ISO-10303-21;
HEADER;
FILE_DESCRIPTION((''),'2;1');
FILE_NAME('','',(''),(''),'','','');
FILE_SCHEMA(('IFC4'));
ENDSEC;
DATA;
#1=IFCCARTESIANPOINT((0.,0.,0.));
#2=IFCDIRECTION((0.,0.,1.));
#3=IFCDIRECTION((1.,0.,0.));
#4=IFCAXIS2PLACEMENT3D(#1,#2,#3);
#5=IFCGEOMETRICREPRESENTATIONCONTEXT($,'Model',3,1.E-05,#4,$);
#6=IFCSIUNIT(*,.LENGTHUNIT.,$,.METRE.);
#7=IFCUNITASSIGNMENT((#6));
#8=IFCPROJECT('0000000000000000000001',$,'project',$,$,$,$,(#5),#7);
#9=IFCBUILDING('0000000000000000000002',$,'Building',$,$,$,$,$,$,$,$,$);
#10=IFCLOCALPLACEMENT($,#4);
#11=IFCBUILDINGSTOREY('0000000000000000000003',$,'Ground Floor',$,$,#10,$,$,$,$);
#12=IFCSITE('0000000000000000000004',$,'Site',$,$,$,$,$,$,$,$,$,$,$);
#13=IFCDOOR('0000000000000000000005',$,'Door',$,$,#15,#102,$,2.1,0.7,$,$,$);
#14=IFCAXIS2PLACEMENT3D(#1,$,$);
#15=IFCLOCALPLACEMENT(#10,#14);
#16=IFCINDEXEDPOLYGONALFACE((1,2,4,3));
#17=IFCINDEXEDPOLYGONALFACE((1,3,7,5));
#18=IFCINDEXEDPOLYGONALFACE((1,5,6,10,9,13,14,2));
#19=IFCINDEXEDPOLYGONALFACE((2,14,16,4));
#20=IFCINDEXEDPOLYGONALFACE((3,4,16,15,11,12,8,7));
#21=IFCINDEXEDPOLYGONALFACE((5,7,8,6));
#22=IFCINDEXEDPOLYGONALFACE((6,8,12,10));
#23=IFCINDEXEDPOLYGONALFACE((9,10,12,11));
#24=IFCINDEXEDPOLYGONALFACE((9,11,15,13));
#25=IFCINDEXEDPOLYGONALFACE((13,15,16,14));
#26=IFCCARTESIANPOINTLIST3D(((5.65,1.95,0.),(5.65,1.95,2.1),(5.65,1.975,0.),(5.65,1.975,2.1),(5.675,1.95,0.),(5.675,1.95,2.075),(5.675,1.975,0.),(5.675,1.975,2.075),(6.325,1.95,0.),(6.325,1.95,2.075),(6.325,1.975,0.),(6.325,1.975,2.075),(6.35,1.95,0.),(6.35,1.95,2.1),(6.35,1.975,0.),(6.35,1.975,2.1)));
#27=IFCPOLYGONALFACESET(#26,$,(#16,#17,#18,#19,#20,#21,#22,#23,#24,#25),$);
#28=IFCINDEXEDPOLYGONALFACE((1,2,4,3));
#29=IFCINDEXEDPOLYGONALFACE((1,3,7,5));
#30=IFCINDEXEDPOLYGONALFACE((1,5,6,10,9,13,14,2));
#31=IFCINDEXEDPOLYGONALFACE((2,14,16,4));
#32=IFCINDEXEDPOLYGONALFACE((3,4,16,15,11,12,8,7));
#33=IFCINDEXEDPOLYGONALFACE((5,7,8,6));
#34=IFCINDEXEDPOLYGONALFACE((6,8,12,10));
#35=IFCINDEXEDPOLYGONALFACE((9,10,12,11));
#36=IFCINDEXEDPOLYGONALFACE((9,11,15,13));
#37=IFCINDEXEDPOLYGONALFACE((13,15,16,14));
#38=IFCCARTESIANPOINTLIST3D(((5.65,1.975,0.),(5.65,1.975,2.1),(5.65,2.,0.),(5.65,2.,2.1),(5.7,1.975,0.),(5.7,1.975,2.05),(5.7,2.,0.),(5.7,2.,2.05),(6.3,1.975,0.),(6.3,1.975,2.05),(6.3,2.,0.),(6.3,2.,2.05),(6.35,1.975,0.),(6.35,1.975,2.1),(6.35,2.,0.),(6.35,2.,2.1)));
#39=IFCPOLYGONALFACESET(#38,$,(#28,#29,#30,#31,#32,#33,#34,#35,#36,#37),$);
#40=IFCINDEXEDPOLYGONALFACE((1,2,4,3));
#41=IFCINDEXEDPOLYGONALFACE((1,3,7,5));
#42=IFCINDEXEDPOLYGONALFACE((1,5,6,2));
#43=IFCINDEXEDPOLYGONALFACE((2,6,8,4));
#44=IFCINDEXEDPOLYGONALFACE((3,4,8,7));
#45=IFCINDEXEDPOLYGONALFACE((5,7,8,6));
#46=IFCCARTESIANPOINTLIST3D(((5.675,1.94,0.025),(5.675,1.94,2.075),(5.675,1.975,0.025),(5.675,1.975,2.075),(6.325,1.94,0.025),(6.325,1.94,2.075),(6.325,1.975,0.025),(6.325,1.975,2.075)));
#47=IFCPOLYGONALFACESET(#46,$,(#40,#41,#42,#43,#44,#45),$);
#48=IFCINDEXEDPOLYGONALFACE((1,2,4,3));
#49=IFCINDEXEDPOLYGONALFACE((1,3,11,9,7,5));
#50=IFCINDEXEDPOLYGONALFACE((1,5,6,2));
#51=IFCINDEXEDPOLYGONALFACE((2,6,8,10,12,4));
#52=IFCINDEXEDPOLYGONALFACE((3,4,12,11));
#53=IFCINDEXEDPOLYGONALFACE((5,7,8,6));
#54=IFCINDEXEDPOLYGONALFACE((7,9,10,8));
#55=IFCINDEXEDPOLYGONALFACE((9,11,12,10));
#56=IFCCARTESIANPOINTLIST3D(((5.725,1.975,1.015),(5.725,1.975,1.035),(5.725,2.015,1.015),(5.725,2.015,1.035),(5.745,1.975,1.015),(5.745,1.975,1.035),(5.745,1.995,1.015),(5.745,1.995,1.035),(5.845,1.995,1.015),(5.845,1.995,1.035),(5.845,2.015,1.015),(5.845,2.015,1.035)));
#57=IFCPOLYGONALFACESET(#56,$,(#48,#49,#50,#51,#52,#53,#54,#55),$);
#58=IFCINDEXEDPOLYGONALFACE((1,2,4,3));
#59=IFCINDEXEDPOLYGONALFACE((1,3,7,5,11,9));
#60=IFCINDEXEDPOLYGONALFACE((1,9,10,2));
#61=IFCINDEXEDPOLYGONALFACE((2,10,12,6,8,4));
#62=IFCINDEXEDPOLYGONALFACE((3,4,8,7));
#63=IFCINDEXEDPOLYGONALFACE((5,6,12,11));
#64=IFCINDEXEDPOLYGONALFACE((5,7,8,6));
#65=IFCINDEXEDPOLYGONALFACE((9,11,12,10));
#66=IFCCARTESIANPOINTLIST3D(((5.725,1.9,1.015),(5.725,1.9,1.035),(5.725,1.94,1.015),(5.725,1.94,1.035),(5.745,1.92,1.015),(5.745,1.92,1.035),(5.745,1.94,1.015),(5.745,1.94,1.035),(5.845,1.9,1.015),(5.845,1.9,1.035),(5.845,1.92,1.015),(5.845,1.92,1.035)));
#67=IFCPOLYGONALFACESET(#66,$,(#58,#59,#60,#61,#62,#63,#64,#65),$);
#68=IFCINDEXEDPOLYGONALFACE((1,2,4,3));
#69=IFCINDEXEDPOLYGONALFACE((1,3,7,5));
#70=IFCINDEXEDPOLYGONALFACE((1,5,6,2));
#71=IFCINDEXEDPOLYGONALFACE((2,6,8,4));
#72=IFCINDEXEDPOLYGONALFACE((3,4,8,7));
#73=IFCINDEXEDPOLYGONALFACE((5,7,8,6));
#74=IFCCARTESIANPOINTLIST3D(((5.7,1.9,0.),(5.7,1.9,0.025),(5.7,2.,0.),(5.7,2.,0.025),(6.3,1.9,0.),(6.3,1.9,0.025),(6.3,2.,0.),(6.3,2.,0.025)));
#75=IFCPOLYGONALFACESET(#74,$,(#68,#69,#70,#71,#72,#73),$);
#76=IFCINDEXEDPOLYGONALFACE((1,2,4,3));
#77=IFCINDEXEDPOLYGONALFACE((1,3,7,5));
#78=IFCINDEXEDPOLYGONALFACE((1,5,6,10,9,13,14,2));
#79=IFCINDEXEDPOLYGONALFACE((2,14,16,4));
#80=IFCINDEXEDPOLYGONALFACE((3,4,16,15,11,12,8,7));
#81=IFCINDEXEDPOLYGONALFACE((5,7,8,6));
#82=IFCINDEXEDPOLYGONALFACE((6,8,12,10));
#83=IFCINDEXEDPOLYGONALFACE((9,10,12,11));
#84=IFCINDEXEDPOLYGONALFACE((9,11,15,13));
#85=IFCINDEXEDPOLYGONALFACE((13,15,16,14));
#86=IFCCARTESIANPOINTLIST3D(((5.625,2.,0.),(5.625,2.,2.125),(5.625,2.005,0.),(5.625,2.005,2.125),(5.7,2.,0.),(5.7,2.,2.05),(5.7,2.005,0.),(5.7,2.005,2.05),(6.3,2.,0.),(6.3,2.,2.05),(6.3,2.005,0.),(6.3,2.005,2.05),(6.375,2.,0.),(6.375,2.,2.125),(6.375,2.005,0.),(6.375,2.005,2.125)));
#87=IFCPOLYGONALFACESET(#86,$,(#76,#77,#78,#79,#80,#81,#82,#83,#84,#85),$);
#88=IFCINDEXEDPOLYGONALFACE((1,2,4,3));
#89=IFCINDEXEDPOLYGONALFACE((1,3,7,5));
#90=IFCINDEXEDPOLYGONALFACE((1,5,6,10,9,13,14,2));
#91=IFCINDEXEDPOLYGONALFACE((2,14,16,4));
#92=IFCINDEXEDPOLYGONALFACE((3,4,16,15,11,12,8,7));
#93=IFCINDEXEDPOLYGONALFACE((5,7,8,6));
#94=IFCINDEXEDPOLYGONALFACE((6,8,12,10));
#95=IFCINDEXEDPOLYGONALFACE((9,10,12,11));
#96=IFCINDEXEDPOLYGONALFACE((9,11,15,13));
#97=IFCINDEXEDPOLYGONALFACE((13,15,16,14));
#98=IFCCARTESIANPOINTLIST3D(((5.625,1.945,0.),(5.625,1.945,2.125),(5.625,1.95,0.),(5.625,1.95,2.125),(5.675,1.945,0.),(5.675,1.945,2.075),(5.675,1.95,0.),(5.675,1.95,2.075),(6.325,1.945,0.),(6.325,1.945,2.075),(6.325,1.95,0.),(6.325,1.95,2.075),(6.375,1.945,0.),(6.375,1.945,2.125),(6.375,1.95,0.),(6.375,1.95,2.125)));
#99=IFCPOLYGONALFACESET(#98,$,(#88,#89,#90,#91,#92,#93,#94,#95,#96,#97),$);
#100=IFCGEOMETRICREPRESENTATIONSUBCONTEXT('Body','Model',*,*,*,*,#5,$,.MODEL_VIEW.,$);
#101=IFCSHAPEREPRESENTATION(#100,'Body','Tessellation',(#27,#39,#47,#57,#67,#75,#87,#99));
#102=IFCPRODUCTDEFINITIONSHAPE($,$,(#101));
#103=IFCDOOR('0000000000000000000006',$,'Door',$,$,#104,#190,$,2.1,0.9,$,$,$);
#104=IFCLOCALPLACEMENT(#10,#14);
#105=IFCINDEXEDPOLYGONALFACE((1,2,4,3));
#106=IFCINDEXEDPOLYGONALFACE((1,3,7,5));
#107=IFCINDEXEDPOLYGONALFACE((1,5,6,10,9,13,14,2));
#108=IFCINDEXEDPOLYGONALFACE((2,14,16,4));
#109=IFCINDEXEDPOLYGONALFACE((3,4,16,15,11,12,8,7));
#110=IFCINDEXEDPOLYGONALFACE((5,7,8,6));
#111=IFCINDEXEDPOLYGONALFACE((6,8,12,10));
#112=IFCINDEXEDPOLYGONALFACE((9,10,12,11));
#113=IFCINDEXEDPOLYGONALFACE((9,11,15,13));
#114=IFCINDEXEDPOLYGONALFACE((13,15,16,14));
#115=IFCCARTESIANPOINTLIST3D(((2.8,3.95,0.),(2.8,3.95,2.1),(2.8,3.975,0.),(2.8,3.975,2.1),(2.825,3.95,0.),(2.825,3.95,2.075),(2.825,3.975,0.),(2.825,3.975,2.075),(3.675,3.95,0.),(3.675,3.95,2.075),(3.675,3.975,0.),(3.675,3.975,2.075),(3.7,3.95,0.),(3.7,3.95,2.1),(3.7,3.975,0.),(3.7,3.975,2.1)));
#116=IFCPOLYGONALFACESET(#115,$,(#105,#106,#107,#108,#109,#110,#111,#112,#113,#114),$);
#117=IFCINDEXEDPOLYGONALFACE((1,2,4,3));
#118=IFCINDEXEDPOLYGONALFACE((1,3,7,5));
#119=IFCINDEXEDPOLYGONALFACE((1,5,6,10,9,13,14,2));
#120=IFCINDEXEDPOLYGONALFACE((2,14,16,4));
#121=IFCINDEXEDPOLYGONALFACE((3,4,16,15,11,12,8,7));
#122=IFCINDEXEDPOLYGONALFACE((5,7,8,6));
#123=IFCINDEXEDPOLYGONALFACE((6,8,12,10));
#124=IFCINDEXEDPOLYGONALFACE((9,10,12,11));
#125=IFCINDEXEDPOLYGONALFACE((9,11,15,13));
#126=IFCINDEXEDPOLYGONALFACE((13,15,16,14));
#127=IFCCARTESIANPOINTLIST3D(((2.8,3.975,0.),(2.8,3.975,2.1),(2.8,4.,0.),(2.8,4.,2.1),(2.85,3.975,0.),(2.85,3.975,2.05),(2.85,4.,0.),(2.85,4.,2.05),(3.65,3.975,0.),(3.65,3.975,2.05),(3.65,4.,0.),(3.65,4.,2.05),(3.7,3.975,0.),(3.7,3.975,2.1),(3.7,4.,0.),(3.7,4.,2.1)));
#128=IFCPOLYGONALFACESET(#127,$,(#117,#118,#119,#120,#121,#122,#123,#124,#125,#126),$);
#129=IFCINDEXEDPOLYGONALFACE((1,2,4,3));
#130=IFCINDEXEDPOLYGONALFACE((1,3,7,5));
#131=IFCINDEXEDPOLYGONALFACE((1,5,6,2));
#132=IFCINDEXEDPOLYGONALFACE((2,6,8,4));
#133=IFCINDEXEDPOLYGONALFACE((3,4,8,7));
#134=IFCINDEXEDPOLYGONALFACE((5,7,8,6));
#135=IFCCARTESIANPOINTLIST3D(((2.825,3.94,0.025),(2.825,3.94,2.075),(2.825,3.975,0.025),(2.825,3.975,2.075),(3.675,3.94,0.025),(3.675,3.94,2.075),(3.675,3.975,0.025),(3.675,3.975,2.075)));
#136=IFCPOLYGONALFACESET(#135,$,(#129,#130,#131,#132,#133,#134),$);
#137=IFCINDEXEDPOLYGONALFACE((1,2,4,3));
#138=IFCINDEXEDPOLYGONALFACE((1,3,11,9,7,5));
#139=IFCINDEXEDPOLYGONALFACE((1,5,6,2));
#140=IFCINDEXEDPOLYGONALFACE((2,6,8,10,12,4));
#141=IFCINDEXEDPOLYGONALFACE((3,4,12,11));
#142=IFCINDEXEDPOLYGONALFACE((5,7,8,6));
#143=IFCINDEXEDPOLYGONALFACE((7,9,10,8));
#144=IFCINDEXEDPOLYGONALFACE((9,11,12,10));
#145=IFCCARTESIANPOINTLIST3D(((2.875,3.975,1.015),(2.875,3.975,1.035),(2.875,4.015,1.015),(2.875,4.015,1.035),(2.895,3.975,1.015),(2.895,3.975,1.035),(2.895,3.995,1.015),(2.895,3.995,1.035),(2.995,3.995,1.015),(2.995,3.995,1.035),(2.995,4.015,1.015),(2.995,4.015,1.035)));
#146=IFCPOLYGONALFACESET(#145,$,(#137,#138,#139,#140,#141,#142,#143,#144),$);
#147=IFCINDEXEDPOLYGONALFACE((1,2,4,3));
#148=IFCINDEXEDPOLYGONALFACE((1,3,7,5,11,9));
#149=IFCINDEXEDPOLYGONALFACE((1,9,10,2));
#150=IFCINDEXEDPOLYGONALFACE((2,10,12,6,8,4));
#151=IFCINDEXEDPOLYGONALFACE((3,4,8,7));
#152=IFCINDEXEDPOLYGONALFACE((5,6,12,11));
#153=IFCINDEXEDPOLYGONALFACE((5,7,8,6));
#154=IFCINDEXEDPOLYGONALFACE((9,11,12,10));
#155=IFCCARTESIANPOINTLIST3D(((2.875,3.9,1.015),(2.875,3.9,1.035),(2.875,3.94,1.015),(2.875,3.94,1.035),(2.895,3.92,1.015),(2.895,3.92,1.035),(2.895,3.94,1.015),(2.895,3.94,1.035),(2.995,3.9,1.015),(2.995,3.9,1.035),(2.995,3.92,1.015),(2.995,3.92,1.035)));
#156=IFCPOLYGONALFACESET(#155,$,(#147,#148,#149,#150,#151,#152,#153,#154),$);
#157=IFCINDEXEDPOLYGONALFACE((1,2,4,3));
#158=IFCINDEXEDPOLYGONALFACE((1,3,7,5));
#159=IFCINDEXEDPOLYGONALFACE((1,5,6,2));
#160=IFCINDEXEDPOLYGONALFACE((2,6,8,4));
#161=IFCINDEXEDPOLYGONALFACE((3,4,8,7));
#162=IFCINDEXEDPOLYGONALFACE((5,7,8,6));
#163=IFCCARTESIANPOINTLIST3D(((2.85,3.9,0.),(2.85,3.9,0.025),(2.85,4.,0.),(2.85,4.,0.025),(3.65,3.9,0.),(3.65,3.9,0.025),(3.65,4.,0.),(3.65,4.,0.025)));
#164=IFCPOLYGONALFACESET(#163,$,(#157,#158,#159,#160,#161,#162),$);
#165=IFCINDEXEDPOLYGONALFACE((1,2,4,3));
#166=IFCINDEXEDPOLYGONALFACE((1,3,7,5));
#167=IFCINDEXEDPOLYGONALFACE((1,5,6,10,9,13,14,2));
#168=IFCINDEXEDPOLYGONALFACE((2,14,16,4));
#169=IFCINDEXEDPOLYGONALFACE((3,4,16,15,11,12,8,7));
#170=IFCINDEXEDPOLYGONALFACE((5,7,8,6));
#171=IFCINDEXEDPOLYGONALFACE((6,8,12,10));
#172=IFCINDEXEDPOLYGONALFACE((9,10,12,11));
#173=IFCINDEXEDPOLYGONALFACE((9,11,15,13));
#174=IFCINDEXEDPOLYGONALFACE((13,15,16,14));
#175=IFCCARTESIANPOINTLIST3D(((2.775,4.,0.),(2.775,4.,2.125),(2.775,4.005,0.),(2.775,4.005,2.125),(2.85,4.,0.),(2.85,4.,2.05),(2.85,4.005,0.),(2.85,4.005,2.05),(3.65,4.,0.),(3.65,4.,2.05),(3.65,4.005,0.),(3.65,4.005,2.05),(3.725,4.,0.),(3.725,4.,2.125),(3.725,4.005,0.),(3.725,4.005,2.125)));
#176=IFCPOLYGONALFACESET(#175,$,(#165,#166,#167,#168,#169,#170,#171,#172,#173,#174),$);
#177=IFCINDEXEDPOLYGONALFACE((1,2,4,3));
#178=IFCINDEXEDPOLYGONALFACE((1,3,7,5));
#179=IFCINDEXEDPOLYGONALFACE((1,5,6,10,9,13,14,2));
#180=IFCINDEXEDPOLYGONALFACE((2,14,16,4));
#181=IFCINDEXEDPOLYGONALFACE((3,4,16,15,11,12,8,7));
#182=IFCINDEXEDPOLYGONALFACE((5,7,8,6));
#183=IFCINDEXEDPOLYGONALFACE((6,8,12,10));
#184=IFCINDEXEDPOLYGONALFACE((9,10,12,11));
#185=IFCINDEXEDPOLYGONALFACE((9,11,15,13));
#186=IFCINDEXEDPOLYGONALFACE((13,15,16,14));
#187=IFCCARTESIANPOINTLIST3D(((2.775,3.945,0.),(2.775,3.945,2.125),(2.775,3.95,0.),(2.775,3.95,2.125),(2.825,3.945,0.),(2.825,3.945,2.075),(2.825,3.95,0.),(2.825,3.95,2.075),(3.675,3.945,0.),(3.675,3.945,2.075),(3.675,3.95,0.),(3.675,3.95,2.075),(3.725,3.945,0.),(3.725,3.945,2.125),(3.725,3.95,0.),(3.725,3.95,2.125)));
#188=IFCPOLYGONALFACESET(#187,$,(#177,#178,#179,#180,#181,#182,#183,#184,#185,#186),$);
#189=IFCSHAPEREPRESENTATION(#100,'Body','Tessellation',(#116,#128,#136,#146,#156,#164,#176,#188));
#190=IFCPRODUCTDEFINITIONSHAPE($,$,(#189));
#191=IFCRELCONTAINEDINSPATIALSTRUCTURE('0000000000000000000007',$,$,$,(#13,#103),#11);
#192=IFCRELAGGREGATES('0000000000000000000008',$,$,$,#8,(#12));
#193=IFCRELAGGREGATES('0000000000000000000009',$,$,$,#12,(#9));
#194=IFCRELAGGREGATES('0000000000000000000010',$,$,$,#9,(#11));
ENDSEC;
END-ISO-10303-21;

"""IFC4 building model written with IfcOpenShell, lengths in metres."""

from ifc_helpers import new_model, si_unit, frame, origin_with_axes, place, context, subcontext, project, spatial, line, indexed_curve, outline, extrude, element, save


model = new_model("IFC4")

# Units and contexts
model_context = context("Model", 3, precision=1e-05, world=origin_with_axes())
body_context = subcontext(model_context, "Body", "Model", "MODEL_VIEW")
ifc_project = project(units=[si_unit("LENGTHUNIT", "METRE")], contexts=[model_context])

# Site, building, storey
site = spatial("IfcSite", under=ifc_project, Name="Site")
building = spatial("IfcBuilding", under=site, Name="Building")
storey_placement = place(None, origin_with_axes())
storey = spatial("IfcBuildingStorey", under=building, at=storey_placement, Name="Ground Floor")

# Doors
door_1_placement = place(storey_placement, frame((6.35, 2.0, 0.0), z_axis=(0.0, 0.0, 1.0), x_axis=(-1.0, 0.0, 0.0)))
element("IfcDoor", 1, at=door_1_placement, inside=storey, Name="Door", OverallHeight=2.1, OverallWidth=0.7, context=body_context, shape_type="SweptSolid", body=[
    extrude(outline(indexed_curve([(0.0, 0.0), (0.0, 2.1), (0.7, 2.1), (0.7, 0.0), (0.675, 0.0), (0.675, 2.075), (0.025, 2.075), (0.025, 0.0)], segments=[line(1, 2, 3, 4, 5, 6, 7, 8, 1)])), frame((0.0, 0.025, 0.0), z_axis=(0.0, -1.0, 0.0), x_axis=(1.0, 0.0, 0.0)), (0.0, 0.0, -1.0), 0.025),
    extrude(outline(indexed_curve([(0.0, 0.0), (0.0, 2.1), (0.7, 2.1), (0.7, 0.0), (0.65, 0.0), (0.65, 2.05), (0.05, 2.05), (0.05, 0.0)], segments=[line(1, 2, 3, 4, 5, 6, 7, 8, 1)])), frame((0.0, 0.0, 0.0), z_axis=(0.0, -1.0, 0.0), x_axis=(1.0, 0.0, 0.0)), (0.0, 0.0, -1.0), 0.025),
    extrude(outline(indexed_curve([(0.0, 0.0), (0.65, 0.0), (0.65, 0.035), (0.0, 0.035)], segments=[line(1, 2, 3, 4, 1)])), frame((0.025, 0.025, 0.025), z_axis=(0.0, 0.0, 1.0), x_axis=(1.0, 0.0, 0.0)), (0.0, 0.0, 1.0), 2.05),
    extrude(outline(indexed_curve([(0.0, 0.0), (0.0, -0.04), (-0.12, -0.04), (-0.12, -0.02), (-0.02, -0.02), (-0.02, 0.0)], segments=[line(1, 2, 3, 4, 5, 6, 1)])), frame((0.625, 0.025, 1.015), z_axis=(0.0, 0.0, 1.0), x_axis=(1.0, 0.0, 0.0)), (0.0, 0.0, 1.0), 0.02),
    extrude(outline(indexed_curve([(0.0, 0.0), (0.0, 0.04), (-0.12, 0.04), (-0.12, 0.02), (-0.02, 0.02), (-0.02, 0.0)], segments=[line(1, 2, 3, 4, 5, 6, 1)])), frame((0.625, 0.06, 1.015), z_axis=(0.0, 0.0, 1.0), x_axis=(1.0, 0.0, 0.0)), (0.0, 0.0, 1.0), 0.02),
    extrude(outline(indexed_curve([(0.0, 0.0), (0.6, 0.0), (0.6, 0.1), (0.0, 0.1)], segments=[line(1, 2, 3, 4, 1)])), frame((0.05, 0.0, 0.0), z_axis=(0.0, 0.0, 1.0), x_axis=(1.0, 0.0, 0.0)), (0.0, 0.0, 1.0), 0.025),
    extrude(outline(indexed_curve([(0.0, 0.0), (0.0, 2.125), (0.75, 2.125), (0.75, 0.0), (0.675, 0.0), (0.675, 2.05), (0.075, 2.05), (0.075, 0.0)], segments=[line(1, 2, 3, 4, 5, 6, 7, 8, 1)])), frame((-0.025, -0.005, 0.0), z_axis=(0.0, -1.0, 0.0), x_axis=(1.0, 0.0, 0.0)), (0.0, 0.0, -1.0), 0.005),
    extrude(outline(indexed_curve([(0.0, 0.0), (0.0, 2.125), (0.75, 2.125), (0.75, 0.0), (0.7, 0.0), (0.7, 2.075), (0.05, 2.075), (0.05, 0.0)], segments=[line(1, 2, 3, 4, 5, 6, 7, 8, 1)])), frame((-0.025, 0.05, 0.0), z_axis=(0.0, -1.0, 0.0), x_axis=(1.0, 0.0, 0.0)), (0.0, 0.0, -1.0), 0.005),
])
door_2_placement = place(storey_placement, frame((3.7, 4.0, 0.0), z_axis=(0.0, 0.0, 1.0), x_axis=(-1.0, 0.0, 0.0)))
element("IfcDoor", 2, at=door_2_placement, inside=storey, Name="Door", OverallHeight=2.1, OverallWidth=0.9, context=body_context, shape_type="SweptSolid", body=[
    extrude(outline(indexed_curve([(0.0, 0.0), (0.0, 2.1), (0.9, 2.1), (0.9, 0.0), (0.875, 0.0), (0.875, 2.075), (0.025, 2.075), (0.025, 0.0)], segments=[line(1, 2, 3, 4, 5, 6, 7, 8, 1)])), frame((0.0, 0.025, 0.0), z_axis=(0.0, -1.0, 0.0), x_axis=(1.0, 0.0, 0.0)), (0.0, 0.0, -1.0), 0.025),
    extrude(outline(indexed_curve([(0.0, 0.0), (0.0, 2.1), (0.9, 2.1), (0.9, 0.0), (0.85, 0.0), (0.85, 2.05), (0.05, 2.05), (0.05, 0.0)], segments=[line(1, 2, 3, 4, 5, 6, 7, 8, 1)])), frame((0.0, 0.0, 0.0), z_axis=(0.0, -1.0, 0.0), x_axis=(1.0, 0.0, 0.0)), (0.0, 0.0, -1.0), 0.025),
    extrude(outline(indexed_curve([(0.0, 0.0), (0.85, 0.0), (0.85, 0.035), (0.0, 0.035)], segments=[line(1, 2, 3, 4, 1)])), frame((0.025, 0.025, 0.025), z_axis=(0.0, 0.0, 1.0), x_axis=(1.0, 0.0, 0.0)), (0.0, 0.0, 1.0), 2.05),
    extrude(outline(indexed_curve([(0.0, 0.0), (0.0, -0.04), (-0.12, -0.04), (-0.12, -0.02), (-0.02, -0.02), (-0.02, 0.0)], segments=[line(1, 2, 3, 4, 5, 6, 1)])), frame((0.825, 0.025, 1.015), z_axis=(0.0, 0.0, 1.0), x_axis=(1.0, 0.0, 0.0)), (0.0, 0.0, 1.0), 0.02),
    extrude(outline(indexed_curve([(0.0, 0.0), (0.0, 0.04), (-0.12, 0.04), (-0.12, 0.02), (-0.02, 0.02), (-0.02, 0.0)], segments=[line(1, 2, 3, 4, 5, 6, 1)])), frame((0.825, 0.06, 1.015), z_axis=(0.0, 0.0, 1.0), x_axis=(1.0, 0.0, 0.0)), (0.0, 0.0, 1.0), 0.02),
    extrude(outline(indexed_curve([(0.0, 0.0), (0.8, 0.0), (0.8, 0.1), (0.0, 0.1)], segments=[line(1, 2, 3, 4, 1)])), frame((0.05, 0.0, 0.0), z_axis=(0.0, 0.0, 1.0), x_axis=(1.0, 0.0, 0.0)), (0.0, 0.0, 1.0), 0.025),
    extrude(outline(indexed_curve([(0.0, 0.0), (0.0, 2.125), (0.95, 2.125), (0.95, 0.0), (0.875, 0.0), (0.875, 2.05), (0.075, 2.05), (0.075, 0.0)], segments=[line(1, 2, 3, 4, 5, 6, 7, 8, 1)])), frame((-0.025, -0.005, 0.0), z_axis=(0.0, -1.0, 0.0), x_axis=(1.0, 0.0, 0.0)), (0.0, 0.0, -1.0), 0.005),
    extrude(outline(indexed_curve([(0.0, 0.0), (0.0, 2.125), (0.95, 2.125), (0.95, 0.0), (0.9, 0.0), (0.9, 2.075), (0.05, 2.075), (0.05, 0.0)], segments=[line(1, 2, 3, 4, 5, 6, 7, 8, 1)])), frame((-0.025, 0.05, 0.0), z_axis=(0.0, -1.0, 0.0), x_axis=(1.0, 0.0, 0.0)), (0.0, 0.0, -1.0), 0.005),
])

save(model, "model.ifc")
